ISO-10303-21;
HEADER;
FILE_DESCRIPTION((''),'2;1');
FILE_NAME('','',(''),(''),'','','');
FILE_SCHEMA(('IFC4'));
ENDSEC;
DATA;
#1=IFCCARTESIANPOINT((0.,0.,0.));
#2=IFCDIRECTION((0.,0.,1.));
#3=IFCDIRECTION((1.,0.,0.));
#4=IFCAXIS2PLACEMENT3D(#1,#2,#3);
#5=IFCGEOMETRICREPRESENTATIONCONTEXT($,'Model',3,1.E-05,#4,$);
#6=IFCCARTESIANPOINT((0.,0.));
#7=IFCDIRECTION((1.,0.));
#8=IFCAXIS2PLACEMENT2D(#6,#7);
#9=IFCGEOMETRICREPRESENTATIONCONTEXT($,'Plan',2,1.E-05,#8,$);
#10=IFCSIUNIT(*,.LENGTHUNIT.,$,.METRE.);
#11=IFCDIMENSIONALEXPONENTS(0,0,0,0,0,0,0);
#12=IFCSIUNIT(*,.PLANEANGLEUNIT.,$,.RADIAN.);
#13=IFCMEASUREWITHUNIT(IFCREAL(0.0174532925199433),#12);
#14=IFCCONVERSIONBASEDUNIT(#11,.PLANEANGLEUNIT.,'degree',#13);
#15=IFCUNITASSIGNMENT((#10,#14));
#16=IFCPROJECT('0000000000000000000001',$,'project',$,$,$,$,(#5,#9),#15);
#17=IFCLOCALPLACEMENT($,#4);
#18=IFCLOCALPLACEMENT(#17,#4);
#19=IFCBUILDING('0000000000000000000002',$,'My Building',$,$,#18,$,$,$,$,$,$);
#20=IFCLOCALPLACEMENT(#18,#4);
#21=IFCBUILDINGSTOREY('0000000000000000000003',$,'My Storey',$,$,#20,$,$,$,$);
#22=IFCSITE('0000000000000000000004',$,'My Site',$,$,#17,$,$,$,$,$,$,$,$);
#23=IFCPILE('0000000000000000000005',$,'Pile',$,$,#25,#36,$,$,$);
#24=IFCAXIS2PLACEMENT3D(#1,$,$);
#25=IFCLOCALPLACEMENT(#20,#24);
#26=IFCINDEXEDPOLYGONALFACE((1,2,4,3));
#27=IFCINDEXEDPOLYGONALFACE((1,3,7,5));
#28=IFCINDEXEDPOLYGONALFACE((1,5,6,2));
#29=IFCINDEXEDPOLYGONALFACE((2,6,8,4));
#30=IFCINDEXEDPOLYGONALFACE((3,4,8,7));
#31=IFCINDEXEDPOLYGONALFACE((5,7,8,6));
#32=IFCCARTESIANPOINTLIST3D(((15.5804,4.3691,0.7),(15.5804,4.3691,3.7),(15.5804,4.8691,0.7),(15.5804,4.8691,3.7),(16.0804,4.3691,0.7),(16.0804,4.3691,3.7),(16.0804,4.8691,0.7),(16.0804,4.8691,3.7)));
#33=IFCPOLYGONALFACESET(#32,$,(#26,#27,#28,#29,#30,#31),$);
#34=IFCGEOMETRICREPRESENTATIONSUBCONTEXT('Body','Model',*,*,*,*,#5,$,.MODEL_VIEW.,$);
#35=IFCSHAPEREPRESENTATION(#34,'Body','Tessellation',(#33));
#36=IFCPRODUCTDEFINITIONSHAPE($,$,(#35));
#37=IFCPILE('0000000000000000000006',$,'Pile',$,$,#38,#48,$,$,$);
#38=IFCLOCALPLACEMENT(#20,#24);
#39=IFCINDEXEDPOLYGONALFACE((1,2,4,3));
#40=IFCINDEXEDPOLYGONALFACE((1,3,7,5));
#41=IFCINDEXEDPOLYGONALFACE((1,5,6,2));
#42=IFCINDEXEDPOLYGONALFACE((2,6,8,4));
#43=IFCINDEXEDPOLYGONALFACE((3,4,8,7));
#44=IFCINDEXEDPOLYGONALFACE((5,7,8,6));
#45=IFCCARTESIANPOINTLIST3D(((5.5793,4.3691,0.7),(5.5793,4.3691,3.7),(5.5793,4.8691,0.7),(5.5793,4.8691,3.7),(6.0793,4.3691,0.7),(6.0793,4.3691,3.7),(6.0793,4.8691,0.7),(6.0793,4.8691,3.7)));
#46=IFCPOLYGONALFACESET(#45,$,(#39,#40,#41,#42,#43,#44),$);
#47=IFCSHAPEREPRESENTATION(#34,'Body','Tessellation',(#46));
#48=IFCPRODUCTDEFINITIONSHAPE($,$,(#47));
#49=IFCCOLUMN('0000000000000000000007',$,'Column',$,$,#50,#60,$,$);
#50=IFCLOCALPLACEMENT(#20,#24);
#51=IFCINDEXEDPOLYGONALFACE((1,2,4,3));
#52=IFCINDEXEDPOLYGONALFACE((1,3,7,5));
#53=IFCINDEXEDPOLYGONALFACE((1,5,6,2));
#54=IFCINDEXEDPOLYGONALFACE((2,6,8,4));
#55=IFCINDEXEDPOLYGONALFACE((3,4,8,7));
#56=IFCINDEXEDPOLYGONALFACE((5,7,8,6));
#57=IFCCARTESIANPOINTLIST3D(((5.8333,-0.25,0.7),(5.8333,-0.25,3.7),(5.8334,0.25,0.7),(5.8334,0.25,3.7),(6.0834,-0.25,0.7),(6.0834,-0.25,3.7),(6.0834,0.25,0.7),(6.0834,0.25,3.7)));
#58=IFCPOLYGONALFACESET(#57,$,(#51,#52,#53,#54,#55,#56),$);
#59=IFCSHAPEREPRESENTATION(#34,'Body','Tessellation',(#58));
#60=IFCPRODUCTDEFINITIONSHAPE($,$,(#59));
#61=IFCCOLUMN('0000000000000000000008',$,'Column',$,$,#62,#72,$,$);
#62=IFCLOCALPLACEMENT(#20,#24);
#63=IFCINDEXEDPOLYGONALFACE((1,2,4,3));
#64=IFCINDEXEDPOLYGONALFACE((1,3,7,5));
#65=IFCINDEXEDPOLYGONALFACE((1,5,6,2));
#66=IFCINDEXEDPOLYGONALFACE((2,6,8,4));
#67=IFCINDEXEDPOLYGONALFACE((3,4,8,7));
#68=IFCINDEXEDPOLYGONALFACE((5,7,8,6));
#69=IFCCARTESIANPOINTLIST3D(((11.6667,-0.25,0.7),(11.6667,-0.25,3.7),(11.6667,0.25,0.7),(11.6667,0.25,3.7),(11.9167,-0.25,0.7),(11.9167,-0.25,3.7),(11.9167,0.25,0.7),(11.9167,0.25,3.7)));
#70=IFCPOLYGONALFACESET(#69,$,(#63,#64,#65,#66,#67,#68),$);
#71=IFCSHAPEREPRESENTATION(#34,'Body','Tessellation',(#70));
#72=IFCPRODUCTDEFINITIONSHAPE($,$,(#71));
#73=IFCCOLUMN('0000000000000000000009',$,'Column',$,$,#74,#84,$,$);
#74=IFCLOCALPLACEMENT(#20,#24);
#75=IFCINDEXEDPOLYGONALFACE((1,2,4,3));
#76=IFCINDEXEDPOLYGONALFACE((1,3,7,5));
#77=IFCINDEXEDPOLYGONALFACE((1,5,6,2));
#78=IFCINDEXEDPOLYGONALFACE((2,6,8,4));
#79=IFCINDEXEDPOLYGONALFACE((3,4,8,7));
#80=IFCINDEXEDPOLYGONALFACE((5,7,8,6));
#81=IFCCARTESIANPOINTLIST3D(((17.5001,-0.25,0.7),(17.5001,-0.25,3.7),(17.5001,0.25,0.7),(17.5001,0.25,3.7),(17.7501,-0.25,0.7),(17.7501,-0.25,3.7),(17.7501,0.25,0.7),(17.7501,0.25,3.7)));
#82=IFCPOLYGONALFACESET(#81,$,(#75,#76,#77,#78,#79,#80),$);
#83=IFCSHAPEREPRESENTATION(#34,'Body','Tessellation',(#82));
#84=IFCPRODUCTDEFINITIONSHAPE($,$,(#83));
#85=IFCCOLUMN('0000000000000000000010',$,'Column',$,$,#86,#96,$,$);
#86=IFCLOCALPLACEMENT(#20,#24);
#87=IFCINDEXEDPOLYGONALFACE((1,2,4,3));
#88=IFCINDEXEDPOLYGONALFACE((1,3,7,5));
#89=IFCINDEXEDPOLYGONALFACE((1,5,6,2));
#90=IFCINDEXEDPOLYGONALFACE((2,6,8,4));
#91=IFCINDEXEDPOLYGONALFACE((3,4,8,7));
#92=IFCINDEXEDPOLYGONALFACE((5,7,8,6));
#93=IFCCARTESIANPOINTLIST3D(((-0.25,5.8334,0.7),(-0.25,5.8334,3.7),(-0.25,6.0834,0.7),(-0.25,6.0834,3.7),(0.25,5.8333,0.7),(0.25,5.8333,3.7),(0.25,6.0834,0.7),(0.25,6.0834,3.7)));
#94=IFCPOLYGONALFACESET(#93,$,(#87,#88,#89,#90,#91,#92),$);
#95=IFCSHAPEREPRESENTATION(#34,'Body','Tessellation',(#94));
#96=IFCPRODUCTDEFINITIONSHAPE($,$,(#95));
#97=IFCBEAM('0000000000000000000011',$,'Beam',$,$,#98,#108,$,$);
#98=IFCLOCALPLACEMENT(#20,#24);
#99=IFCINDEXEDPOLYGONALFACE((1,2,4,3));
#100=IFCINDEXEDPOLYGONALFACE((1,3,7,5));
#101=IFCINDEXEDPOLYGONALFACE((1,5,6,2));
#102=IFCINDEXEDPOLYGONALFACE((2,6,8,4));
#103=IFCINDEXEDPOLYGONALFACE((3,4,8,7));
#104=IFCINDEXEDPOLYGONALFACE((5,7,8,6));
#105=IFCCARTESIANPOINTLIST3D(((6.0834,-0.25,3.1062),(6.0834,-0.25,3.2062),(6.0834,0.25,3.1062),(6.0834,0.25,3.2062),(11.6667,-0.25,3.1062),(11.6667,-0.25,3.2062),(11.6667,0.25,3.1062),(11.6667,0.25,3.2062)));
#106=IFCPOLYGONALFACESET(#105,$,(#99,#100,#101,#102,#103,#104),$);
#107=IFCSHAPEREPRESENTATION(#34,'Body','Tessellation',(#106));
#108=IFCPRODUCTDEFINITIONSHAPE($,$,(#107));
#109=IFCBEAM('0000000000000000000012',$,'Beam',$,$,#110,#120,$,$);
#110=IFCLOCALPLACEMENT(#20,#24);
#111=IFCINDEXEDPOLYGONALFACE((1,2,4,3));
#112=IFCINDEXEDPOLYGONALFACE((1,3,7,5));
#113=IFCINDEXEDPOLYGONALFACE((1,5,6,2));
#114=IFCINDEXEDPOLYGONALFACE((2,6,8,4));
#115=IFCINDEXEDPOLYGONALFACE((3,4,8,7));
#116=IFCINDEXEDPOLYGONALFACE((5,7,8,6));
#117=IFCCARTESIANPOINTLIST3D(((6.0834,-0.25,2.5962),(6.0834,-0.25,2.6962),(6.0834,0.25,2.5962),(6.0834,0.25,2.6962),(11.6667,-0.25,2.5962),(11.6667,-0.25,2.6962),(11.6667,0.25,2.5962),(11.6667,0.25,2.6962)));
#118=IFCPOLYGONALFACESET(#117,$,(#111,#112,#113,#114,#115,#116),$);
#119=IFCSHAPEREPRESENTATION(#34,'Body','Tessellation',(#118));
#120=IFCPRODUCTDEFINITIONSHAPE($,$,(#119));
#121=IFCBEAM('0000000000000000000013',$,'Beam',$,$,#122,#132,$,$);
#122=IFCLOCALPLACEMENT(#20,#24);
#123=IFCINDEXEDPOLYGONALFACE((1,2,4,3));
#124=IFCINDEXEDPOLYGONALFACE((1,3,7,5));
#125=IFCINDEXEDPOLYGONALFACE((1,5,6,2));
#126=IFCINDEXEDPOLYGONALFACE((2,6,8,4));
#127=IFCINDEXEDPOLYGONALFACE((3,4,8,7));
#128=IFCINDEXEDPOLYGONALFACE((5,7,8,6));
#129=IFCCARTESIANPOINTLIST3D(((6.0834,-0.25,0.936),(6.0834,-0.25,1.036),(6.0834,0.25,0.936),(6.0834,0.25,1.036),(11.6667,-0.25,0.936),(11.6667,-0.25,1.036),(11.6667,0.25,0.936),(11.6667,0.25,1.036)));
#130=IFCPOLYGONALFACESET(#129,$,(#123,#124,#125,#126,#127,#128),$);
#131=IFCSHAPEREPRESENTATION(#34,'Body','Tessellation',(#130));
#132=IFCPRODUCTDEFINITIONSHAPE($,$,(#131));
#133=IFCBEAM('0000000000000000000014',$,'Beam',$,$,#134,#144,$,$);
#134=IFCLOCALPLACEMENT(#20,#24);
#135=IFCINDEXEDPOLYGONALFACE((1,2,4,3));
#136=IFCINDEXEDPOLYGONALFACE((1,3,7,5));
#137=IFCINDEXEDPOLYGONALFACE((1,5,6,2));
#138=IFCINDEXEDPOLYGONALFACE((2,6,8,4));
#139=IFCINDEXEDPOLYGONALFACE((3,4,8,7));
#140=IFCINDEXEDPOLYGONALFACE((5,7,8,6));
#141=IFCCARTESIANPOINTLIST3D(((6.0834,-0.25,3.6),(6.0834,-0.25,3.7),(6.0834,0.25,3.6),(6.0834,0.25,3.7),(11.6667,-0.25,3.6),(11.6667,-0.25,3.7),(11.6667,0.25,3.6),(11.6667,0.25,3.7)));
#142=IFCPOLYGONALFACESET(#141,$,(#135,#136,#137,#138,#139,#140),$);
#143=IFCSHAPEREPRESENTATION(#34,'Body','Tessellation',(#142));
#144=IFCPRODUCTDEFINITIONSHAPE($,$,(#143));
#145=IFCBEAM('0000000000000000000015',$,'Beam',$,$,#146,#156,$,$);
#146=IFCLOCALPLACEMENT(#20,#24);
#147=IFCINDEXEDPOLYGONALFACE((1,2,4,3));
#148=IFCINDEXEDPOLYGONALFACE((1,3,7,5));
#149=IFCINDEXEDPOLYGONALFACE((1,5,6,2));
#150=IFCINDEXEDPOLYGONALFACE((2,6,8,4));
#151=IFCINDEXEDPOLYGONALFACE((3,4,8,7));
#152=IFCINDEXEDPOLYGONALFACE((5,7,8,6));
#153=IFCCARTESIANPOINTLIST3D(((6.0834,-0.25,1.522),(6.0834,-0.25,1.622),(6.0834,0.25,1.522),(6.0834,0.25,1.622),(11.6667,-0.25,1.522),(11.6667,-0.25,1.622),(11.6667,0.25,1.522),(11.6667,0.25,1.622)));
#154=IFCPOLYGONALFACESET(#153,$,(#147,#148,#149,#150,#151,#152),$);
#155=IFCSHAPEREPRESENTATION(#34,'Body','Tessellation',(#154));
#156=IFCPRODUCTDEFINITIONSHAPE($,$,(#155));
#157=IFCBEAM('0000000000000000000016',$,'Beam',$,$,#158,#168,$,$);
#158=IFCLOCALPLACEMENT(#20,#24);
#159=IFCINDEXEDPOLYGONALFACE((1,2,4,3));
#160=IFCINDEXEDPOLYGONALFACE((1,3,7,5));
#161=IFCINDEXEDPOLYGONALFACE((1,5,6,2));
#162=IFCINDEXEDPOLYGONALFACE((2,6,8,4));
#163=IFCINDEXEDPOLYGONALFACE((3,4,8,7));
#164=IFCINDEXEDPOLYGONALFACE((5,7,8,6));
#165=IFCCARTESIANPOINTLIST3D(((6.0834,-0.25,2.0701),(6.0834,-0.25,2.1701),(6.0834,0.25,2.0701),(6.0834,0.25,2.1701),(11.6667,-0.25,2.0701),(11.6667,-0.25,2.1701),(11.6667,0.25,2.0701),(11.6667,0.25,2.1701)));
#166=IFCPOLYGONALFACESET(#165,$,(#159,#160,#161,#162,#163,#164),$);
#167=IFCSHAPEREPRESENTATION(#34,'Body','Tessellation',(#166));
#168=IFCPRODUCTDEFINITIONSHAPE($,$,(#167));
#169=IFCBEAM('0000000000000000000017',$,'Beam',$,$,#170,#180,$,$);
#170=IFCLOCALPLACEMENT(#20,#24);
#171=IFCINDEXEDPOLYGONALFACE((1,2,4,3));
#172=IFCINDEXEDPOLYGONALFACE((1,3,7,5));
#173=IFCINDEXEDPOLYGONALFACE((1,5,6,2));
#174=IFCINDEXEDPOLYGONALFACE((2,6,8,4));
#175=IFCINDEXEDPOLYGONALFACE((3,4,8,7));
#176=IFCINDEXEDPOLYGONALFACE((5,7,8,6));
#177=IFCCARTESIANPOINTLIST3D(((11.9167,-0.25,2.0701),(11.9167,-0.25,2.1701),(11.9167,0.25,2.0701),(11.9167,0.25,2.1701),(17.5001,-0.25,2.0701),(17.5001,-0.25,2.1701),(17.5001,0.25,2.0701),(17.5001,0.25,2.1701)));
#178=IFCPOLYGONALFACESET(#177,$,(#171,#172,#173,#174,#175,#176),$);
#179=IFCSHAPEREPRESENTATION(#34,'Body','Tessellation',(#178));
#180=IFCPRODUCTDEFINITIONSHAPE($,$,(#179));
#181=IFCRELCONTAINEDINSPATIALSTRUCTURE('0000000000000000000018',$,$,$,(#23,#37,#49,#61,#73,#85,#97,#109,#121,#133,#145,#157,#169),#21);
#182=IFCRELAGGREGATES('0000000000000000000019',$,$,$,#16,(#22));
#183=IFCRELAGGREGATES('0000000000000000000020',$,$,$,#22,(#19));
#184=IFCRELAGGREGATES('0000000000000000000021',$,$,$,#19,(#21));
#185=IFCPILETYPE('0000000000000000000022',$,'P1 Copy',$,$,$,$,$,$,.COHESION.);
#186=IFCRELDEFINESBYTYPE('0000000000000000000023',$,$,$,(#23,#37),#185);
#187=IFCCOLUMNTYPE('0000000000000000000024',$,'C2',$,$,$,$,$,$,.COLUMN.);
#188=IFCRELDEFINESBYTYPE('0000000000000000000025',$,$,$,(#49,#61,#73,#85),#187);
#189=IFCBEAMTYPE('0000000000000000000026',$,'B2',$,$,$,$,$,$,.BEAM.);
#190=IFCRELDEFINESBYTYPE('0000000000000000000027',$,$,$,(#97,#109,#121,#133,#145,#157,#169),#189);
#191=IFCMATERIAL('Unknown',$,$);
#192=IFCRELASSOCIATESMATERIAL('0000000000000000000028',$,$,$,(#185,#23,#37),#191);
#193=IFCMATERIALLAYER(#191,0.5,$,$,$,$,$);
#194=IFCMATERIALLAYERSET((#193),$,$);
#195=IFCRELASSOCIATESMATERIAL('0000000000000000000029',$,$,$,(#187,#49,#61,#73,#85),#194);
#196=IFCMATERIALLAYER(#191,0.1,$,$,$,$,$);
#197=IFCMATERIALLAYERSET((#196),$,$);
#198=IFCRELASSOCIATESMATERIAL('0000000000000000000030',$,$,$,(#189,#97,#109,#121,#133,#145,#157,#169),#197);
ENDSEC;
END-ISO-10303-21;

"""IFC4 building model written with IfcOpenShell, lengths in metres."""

from ifc_helpers import new_model, entity, si_unit, converted_unit, frame, origin_with_axes, origin_2d_with_axis, place, context, subcontext, project, spatial, line, indexed_curve, rectangle, outline, extrude, material, layer, layer_set, layer_usage, material_profile, profile_set, profile_usage, type_object, element, save


model = new_model("IFC4")

# Units and contexts
model_context = context("Model", 3, precision=1e-05, world=origin_with_axes())
plan_context = context("Plan", 2, precision=1e-05, world=origin_2d_with_axis())
body_context = subcontext(model_context, "Body", "Model", "MODEL_VIEW")
ifc_project = project(units=[si_unit("LENGTHUNIT", "METRE"), converted_unit("PLANEANGLEUNIT", "degree", entity("IfcReal", 0.0174532925199433), si_unit("PLANEANGLEUNIT", "RADIAN"), dimensions=[0, 0, 0, 0, 0, 0, 0])], contexts=[model_context, plan_context])

# Site, building, storey
site_placement = place(None, origin_with_axes())
site = spatial("IfcSite", under=ifc_project, at=site_placement, Name="My Site")
building_placement = place(site_placement, origin_with_axes())
building = spatial("IfcBuilding", under=site, at=building_placement, Name="My Building")
storey_placement = place(building_placement, origin_with_axes())
storey = spatial("IfcBuildingStorey", under=building, at=storey_placement, Name="My Storey")

# Piles
ifc_material = material(Name="Unknown")
ifc_material_profile = material_profile(ifc_material, rectangle(XDim=0.5, YDim=0.5))
ifc_profile_set = profile_set([ifc_material_profile])
ifc_profile_usage_1 = profile_usage(ifc_profile_set, cardinal=8)
pile_type = type_object("IfcPileType", Name="P1 Copy", PredefinedType="COHESION", material=ifc_profile_set)
pile_1_placement = place(storey_placement, frame((15.8304, 4.8691, 0.7), z_axis=(0.0, 0.0, 1.0), x_axis=(1.0, 0.0, 0.0)))
element("IfcPile", 1, at=pile_1_placement, inside=storey, type_object=pile_type, material=ifc_profile_usage_1, Name="Pile", context=body_context, shape_type="SweptSolid", body=[
    extrude(rectangle(XDim=0.5, YDim=0.5), frame((0.0, -0.25, 0.0), z_axis=(0.0, 0.0, 1.0), x_axis=(1.0, 0.0, 0.0)), (0.0, 0.0, 1.0), 3.0),
])
ifc_profile_usage_2 = profile_usage(ifc_profile_set, cardinal=8)
pile_2_placement = place(storey_placement, frame((5.8293, 4.8691, 0.7), z_axis=(0.0, 0.0, 1.0), x_axis=(1.0, 0.0, 0.0)))
element("IfcPile", 2, at=pile_2_placement, inside=storey, type_object=pile_type, material=ifc_profile_usage_2, Name="Pile", context=body_context, shape_type="SweptSolid", body=[
    extrude(rectangle(XDim=0.5, YDim=0.5), frame((0.0, -0.25, 0.0), z_axis=(0.0, 0.0, 1.0), x_axis=(1.0, 0.0, 0.0)), (0.0, 0.0, 1.0), 3.0),
])

# Columns
ifc_layer_1 = layer(ifc_material, 0.5)
ifc_layer_set_1 = layer_set([ifc_layer_1])
ifc_layer_usage_1 = layer_usage(ifc_layer_set_1, "AXIS2", "POSITIVE", 0.0)
column_type = type_object("IfcColumnType", Name="C2", PredefinedType="COLUMN", material=ifc_layer_set_1)
column_1_placement = place(storey_placement, frame((5.8333, -0.25, 0.7), z_axis=(0.0, 0.0, 1.0), x_axis=(1.0, -0.000008, 0.0)))
element("IfcColumn", 3, at=column_1_placement, inside=storey, type_object=column_type, material=ifc_layer_usage_1, Name="Column", context=body_context, shape_type="SweptSolid", body=[
    extrude(outline(indexed_curve([(0.0, 0.0), (0.0, 0.5), (0.25, 0.5), (0.25, 0.0)], segments=[line(1, 2, 3, 4, 1)])), origin_with_axes(), (0.0, 0.0, 1.0), 3.0),
])
ifc_layer_usage_2 = layer_usage(ifc_layer_set_1, "AXIS2", "POSITIVE", 0.0)
column_2_placement = place(storey_placement, frame((11.6667, -0.25, 0.7), z_axis=(0.0, 0.0, 1.0), x_axis=(1.0, -0.000008, 0.0)))
element("IfcColumn", 4, at=column_2_placement, inside=storey, type_object=column_type, material=ifc_layer_usage_2, Name="Column", context=body_context, shape_type="SweptSolid", body=[
    extrude(outline(indexed_curve([(0.0, 0.0), (0.0, 0.5), (0.25, 0.5), (0.25, 0.0)], segments=[line(1, 2, 3, 4, 1)])), origin_with_axes(), (0.0, 0.0, 1.0), 3.0),
])
ifc_layer_usage_3 = layer_usage(ifc_layer_set_1, "AXIS2", "POSITIVE", 0.0)
column_3_placement = place(storey_placement, frame((17.5001, -0.25, 0.7), z_axis=(0.0, 0.0, 1.0), x_axis=(1.0, -0.000008, 0.0)))
element("IfcColumn", 5, at=column_3_placement, inside=storey, type_object=column_type, material=ifc_layer_usage_3, Name="Column", context=body_context, shape_type="SweptSolid", body=[
    extrude(outline(indexed_curve([(0.0, 0.0), (0.0, 0.5), (0.25, 0.5), (0.25, 0.0)], segments=[line(1, 2, 3, 4, 1)])), origin_with_axes(), (0.0, 0.0, 1.0), 3.0),
])
ifc_layer_usage_4 = layer_usage(ifc_layer_set_1, "AXIS2", "POSITIVE", 0.0)
column_4_placement = place(storey_placement, frame((0.25, 5.8333, 0.7), z_axis=(0.0, 0.0, 1.0), x_axis=(0.000007, 1.0, 0.0)))
element("IfcColumn", 6, at=column_4_placement, inside=storey, type_object=column_type, material=ifc_layer_usage_4, Name="Column", context=body_context, shape_type="SweptSolid", body=[
    extrude(outline(indexed_curve([(0.0, 0.0), (0.0, 0.5), (0.25, 0.5), (0.25, 0.0)], segments=[line(1, 2, 3, 4, 1)])), origin_with_axes(), (0.0, 0.0, 1.0), 3.0),
])

# Beams
ifc_layer_2 = layer(ifc_material, 0.1)
ifc_layer_set_2 = layer_set([ifc_layer_2])
ifc_layer_usage_5 = layer_usage(ifc_layer_set_2, "AXIS3", "POSITIVE", -0.1)
beam_type_1 = type_object("IfcBeamType", Name="B2", PredefinedType="BEAM", material=ifc_layer_set_2)
beam_1_placement = place(storey_placement, frame((6.0834, 0.25, 3.2062), z_axis=(0.0, 0.0, 1.0), x_axis=(1.0, 0.0, 0.0)))
element("IfcBeam", 7, at=beam_1_placement, inside=storey, type_object=beam_type_1, material=ifc_layer_usage_5, Name="Beam", context=body_context, shape_type="SweptSolid", body=[
    extrude(outline(indexed_curve([(0.0, 0.0), (0.0, -0.5), (5.5833, -0.5), (5.5834, 0.0), (0.0, 0.0)])), frame((0.0, 0.0, -0.1), z_axis=(0.0, 0.0, 1.0), x_axis=(1.0, 0.0, 0.0)), (0.0, 0.0, 1.0), 0.1),
])
ifc_layer_usage_6 = layer_usage(ifc_layer_set_2, "AXIS3", "POSITIVE", -0.1)
beam_2_placement = place(storey_placement, frame((6.0834, 0.25, 2.6962), z_axis=(0.0, 0.0, 1.0), x_axis=(1.0, 0.0, 0.0)))
element("IfcBeam", 8, at=beam_2_placement, inside=storey, type_object=beam_type_1, material=ifc_layer_usage_6, Name="Beam", context=body_context, shape_type="SweptSolid", body=[
    extrude(outline(indexed_curve([(0.0, 0.0), (0.0, -0.5), (5.5833, -0.5), (5.5834, 0.0), (0.0, 0.0)])), frame((0.0, 0.0, -0.1), z_axis=(0.0, 0.0, 1.0), x_axis=(1.0, 0.0, 0.0)), (0.0, 0.0, 1.0), 0.1),
])
ifc_layer_usage_7 = layer_usage(ifc_layer_set_2, "AXIS3", "POSITIVE", -0.1)
beam_3_placement = place(storey_placement, frame((6.0834, 0.25, 1.036), z_axis=(0.0, 0.0, 1.0), x_axis=(1.0, 0.0, 0.0)))
element("IfcBeam", 9, at=beam_3_placement, inside=storey, type_object=beam_type_1, material=ifc_layer_usage_7, Name="Beam", context=body_context, shape_type="SweptSolid", body=[
    extrude(outline(indexed_curve([(0.0, 0.0), (0.0, -0.5), (5.5833, -0.5), (5.5834, 0.0), (0.0, 0.0)])), frame((0.0, 0.0, -0.1), z_axis=(0.0, 0.0, 1.0), x_axis=(1.0, 0.0, 0.0)), (0.0, 0.0, 1.0), 0.1),
])
ifc_layer_usage_8 = layer_usage(ifc_layer_set_2, "AXIS3", "POSITIVE", -0.1)
beam_4_placement = place(storey_placement, frame((6.0834, 0.25, 3.7), z_axis=(0.0, 0.0, 1.0), x_axis=(1.0, 0.0, 0.0)))
element("IfcBeam", 10, at=beam_4_placement, inside=storey, type_object=beam_type_1, material=ifc_layer_usage_8, Name="Beam", context=body_context, shape_type="SweptSolid", body=[
    extrude(outline(indexed_curve([(0.0, 0.0), (0.0, -0.5), (5.5833, -0.5), (5.5834, 0.0), (0.0, 0.0)])), frame((0.0, 0.0, -0.1), z_axis=(0.0, 0.0, 1.0), x_axis=(1.0, 0.0, 0.0)), (0.0, 0.0, 1.0), 0.1),
])
ifc_layer_usage_9 = layer_usage(ifc_layer_set_2, "AXIS3", "POSITIVE", -0.1)
beam_5_placement = place(storey_placement, frame((6.0834, 0.25, 1.622), z_axis=(0.0, 0.0, 1.0), x_axis=(1.0, 0.0, 0.0)))
element("IfcBeam", 11, at=beam_5_placement, inside=storey, type_object=beam_type_1, material=ifc_layer_usage_9, Name="Beam", context=body_context, shape_type="SweptSolid", body=[
    extrude(outline(indexed_curve([(0.0, 0.0), (0.0, -0.5), (5.5833, -0.5), (5.5834, 0.0), (0.0, 0.0)])), frame((0.0, 0.0, -0.1), z_axis=(0.0, 0.0, 1.0), x_axis=(1.0, 0.0, 0.0)), (0.0, 0.0, 1.0), 0.1),
])
ifc_layer_usage_10 = layer_usage(ifc_layer_set_2, "AXIS3", "POSITIVE", -0.1)
beam_6_placement = place(storey_placement, frame((6.0834, 0.25, 2.1701), z_axis=(0.0, 0.0, 1.0), x_axis=(1.0, 0.0, 0.0)))
element("IfcBeam", 12, at=beam_6_placement, inside=storey, type_object=beam_type_1, material=ifc_layer_usage_10, Name="Beam", context=body_context, shape_type="SweptSolid", body=[
    extrude(outline(indexed_curve([(0.0, 0.0), (0.0, -0.5), (5.5833, -0.5), (5.5834, 0.0), (0.0, 0.0)])), frame((0.0, 0.0, -0.1), z_axis=(0.0, 0.0, 1.0), x_axis=(1.0, 0.0, 0.0)), (0.0, 0.0, 1.0), 0.1),
])
ifc_layer_usage_11 = layer_usage(ifc_layer_set_2, "AXIS3", "POSITIVE", -0.1)
beam_7_placement = place(storey_placement, frame((11.9167, 0.25, 2.1701), z_axis=(0.0, 0.0, 1.0), x_axis=(1.0, 0.0, 0.0)))
element("IfcBeam", 13, at=beam_7_placement, inside=storey, type_object=beam_type_1, material=ifc_layer_usage_11, Name="Beam", context=body_context, shape_type="SweptSolid", body=[
    extrude(outline(indexed_curve([(0.0, 0.0), (0.0, -0.5), (5.5833, -0.5), (5.5834, 0.0), (0.0, 0.0)])), frame((0.0, 0.0, -0.1), z_axis=(0.0, 0.0, 1.0), x_axis=(1.0, 0.0, 0.0)), (0.0, 0.0, 1.0), 0.1),
])

save(model, "model.ifc")
